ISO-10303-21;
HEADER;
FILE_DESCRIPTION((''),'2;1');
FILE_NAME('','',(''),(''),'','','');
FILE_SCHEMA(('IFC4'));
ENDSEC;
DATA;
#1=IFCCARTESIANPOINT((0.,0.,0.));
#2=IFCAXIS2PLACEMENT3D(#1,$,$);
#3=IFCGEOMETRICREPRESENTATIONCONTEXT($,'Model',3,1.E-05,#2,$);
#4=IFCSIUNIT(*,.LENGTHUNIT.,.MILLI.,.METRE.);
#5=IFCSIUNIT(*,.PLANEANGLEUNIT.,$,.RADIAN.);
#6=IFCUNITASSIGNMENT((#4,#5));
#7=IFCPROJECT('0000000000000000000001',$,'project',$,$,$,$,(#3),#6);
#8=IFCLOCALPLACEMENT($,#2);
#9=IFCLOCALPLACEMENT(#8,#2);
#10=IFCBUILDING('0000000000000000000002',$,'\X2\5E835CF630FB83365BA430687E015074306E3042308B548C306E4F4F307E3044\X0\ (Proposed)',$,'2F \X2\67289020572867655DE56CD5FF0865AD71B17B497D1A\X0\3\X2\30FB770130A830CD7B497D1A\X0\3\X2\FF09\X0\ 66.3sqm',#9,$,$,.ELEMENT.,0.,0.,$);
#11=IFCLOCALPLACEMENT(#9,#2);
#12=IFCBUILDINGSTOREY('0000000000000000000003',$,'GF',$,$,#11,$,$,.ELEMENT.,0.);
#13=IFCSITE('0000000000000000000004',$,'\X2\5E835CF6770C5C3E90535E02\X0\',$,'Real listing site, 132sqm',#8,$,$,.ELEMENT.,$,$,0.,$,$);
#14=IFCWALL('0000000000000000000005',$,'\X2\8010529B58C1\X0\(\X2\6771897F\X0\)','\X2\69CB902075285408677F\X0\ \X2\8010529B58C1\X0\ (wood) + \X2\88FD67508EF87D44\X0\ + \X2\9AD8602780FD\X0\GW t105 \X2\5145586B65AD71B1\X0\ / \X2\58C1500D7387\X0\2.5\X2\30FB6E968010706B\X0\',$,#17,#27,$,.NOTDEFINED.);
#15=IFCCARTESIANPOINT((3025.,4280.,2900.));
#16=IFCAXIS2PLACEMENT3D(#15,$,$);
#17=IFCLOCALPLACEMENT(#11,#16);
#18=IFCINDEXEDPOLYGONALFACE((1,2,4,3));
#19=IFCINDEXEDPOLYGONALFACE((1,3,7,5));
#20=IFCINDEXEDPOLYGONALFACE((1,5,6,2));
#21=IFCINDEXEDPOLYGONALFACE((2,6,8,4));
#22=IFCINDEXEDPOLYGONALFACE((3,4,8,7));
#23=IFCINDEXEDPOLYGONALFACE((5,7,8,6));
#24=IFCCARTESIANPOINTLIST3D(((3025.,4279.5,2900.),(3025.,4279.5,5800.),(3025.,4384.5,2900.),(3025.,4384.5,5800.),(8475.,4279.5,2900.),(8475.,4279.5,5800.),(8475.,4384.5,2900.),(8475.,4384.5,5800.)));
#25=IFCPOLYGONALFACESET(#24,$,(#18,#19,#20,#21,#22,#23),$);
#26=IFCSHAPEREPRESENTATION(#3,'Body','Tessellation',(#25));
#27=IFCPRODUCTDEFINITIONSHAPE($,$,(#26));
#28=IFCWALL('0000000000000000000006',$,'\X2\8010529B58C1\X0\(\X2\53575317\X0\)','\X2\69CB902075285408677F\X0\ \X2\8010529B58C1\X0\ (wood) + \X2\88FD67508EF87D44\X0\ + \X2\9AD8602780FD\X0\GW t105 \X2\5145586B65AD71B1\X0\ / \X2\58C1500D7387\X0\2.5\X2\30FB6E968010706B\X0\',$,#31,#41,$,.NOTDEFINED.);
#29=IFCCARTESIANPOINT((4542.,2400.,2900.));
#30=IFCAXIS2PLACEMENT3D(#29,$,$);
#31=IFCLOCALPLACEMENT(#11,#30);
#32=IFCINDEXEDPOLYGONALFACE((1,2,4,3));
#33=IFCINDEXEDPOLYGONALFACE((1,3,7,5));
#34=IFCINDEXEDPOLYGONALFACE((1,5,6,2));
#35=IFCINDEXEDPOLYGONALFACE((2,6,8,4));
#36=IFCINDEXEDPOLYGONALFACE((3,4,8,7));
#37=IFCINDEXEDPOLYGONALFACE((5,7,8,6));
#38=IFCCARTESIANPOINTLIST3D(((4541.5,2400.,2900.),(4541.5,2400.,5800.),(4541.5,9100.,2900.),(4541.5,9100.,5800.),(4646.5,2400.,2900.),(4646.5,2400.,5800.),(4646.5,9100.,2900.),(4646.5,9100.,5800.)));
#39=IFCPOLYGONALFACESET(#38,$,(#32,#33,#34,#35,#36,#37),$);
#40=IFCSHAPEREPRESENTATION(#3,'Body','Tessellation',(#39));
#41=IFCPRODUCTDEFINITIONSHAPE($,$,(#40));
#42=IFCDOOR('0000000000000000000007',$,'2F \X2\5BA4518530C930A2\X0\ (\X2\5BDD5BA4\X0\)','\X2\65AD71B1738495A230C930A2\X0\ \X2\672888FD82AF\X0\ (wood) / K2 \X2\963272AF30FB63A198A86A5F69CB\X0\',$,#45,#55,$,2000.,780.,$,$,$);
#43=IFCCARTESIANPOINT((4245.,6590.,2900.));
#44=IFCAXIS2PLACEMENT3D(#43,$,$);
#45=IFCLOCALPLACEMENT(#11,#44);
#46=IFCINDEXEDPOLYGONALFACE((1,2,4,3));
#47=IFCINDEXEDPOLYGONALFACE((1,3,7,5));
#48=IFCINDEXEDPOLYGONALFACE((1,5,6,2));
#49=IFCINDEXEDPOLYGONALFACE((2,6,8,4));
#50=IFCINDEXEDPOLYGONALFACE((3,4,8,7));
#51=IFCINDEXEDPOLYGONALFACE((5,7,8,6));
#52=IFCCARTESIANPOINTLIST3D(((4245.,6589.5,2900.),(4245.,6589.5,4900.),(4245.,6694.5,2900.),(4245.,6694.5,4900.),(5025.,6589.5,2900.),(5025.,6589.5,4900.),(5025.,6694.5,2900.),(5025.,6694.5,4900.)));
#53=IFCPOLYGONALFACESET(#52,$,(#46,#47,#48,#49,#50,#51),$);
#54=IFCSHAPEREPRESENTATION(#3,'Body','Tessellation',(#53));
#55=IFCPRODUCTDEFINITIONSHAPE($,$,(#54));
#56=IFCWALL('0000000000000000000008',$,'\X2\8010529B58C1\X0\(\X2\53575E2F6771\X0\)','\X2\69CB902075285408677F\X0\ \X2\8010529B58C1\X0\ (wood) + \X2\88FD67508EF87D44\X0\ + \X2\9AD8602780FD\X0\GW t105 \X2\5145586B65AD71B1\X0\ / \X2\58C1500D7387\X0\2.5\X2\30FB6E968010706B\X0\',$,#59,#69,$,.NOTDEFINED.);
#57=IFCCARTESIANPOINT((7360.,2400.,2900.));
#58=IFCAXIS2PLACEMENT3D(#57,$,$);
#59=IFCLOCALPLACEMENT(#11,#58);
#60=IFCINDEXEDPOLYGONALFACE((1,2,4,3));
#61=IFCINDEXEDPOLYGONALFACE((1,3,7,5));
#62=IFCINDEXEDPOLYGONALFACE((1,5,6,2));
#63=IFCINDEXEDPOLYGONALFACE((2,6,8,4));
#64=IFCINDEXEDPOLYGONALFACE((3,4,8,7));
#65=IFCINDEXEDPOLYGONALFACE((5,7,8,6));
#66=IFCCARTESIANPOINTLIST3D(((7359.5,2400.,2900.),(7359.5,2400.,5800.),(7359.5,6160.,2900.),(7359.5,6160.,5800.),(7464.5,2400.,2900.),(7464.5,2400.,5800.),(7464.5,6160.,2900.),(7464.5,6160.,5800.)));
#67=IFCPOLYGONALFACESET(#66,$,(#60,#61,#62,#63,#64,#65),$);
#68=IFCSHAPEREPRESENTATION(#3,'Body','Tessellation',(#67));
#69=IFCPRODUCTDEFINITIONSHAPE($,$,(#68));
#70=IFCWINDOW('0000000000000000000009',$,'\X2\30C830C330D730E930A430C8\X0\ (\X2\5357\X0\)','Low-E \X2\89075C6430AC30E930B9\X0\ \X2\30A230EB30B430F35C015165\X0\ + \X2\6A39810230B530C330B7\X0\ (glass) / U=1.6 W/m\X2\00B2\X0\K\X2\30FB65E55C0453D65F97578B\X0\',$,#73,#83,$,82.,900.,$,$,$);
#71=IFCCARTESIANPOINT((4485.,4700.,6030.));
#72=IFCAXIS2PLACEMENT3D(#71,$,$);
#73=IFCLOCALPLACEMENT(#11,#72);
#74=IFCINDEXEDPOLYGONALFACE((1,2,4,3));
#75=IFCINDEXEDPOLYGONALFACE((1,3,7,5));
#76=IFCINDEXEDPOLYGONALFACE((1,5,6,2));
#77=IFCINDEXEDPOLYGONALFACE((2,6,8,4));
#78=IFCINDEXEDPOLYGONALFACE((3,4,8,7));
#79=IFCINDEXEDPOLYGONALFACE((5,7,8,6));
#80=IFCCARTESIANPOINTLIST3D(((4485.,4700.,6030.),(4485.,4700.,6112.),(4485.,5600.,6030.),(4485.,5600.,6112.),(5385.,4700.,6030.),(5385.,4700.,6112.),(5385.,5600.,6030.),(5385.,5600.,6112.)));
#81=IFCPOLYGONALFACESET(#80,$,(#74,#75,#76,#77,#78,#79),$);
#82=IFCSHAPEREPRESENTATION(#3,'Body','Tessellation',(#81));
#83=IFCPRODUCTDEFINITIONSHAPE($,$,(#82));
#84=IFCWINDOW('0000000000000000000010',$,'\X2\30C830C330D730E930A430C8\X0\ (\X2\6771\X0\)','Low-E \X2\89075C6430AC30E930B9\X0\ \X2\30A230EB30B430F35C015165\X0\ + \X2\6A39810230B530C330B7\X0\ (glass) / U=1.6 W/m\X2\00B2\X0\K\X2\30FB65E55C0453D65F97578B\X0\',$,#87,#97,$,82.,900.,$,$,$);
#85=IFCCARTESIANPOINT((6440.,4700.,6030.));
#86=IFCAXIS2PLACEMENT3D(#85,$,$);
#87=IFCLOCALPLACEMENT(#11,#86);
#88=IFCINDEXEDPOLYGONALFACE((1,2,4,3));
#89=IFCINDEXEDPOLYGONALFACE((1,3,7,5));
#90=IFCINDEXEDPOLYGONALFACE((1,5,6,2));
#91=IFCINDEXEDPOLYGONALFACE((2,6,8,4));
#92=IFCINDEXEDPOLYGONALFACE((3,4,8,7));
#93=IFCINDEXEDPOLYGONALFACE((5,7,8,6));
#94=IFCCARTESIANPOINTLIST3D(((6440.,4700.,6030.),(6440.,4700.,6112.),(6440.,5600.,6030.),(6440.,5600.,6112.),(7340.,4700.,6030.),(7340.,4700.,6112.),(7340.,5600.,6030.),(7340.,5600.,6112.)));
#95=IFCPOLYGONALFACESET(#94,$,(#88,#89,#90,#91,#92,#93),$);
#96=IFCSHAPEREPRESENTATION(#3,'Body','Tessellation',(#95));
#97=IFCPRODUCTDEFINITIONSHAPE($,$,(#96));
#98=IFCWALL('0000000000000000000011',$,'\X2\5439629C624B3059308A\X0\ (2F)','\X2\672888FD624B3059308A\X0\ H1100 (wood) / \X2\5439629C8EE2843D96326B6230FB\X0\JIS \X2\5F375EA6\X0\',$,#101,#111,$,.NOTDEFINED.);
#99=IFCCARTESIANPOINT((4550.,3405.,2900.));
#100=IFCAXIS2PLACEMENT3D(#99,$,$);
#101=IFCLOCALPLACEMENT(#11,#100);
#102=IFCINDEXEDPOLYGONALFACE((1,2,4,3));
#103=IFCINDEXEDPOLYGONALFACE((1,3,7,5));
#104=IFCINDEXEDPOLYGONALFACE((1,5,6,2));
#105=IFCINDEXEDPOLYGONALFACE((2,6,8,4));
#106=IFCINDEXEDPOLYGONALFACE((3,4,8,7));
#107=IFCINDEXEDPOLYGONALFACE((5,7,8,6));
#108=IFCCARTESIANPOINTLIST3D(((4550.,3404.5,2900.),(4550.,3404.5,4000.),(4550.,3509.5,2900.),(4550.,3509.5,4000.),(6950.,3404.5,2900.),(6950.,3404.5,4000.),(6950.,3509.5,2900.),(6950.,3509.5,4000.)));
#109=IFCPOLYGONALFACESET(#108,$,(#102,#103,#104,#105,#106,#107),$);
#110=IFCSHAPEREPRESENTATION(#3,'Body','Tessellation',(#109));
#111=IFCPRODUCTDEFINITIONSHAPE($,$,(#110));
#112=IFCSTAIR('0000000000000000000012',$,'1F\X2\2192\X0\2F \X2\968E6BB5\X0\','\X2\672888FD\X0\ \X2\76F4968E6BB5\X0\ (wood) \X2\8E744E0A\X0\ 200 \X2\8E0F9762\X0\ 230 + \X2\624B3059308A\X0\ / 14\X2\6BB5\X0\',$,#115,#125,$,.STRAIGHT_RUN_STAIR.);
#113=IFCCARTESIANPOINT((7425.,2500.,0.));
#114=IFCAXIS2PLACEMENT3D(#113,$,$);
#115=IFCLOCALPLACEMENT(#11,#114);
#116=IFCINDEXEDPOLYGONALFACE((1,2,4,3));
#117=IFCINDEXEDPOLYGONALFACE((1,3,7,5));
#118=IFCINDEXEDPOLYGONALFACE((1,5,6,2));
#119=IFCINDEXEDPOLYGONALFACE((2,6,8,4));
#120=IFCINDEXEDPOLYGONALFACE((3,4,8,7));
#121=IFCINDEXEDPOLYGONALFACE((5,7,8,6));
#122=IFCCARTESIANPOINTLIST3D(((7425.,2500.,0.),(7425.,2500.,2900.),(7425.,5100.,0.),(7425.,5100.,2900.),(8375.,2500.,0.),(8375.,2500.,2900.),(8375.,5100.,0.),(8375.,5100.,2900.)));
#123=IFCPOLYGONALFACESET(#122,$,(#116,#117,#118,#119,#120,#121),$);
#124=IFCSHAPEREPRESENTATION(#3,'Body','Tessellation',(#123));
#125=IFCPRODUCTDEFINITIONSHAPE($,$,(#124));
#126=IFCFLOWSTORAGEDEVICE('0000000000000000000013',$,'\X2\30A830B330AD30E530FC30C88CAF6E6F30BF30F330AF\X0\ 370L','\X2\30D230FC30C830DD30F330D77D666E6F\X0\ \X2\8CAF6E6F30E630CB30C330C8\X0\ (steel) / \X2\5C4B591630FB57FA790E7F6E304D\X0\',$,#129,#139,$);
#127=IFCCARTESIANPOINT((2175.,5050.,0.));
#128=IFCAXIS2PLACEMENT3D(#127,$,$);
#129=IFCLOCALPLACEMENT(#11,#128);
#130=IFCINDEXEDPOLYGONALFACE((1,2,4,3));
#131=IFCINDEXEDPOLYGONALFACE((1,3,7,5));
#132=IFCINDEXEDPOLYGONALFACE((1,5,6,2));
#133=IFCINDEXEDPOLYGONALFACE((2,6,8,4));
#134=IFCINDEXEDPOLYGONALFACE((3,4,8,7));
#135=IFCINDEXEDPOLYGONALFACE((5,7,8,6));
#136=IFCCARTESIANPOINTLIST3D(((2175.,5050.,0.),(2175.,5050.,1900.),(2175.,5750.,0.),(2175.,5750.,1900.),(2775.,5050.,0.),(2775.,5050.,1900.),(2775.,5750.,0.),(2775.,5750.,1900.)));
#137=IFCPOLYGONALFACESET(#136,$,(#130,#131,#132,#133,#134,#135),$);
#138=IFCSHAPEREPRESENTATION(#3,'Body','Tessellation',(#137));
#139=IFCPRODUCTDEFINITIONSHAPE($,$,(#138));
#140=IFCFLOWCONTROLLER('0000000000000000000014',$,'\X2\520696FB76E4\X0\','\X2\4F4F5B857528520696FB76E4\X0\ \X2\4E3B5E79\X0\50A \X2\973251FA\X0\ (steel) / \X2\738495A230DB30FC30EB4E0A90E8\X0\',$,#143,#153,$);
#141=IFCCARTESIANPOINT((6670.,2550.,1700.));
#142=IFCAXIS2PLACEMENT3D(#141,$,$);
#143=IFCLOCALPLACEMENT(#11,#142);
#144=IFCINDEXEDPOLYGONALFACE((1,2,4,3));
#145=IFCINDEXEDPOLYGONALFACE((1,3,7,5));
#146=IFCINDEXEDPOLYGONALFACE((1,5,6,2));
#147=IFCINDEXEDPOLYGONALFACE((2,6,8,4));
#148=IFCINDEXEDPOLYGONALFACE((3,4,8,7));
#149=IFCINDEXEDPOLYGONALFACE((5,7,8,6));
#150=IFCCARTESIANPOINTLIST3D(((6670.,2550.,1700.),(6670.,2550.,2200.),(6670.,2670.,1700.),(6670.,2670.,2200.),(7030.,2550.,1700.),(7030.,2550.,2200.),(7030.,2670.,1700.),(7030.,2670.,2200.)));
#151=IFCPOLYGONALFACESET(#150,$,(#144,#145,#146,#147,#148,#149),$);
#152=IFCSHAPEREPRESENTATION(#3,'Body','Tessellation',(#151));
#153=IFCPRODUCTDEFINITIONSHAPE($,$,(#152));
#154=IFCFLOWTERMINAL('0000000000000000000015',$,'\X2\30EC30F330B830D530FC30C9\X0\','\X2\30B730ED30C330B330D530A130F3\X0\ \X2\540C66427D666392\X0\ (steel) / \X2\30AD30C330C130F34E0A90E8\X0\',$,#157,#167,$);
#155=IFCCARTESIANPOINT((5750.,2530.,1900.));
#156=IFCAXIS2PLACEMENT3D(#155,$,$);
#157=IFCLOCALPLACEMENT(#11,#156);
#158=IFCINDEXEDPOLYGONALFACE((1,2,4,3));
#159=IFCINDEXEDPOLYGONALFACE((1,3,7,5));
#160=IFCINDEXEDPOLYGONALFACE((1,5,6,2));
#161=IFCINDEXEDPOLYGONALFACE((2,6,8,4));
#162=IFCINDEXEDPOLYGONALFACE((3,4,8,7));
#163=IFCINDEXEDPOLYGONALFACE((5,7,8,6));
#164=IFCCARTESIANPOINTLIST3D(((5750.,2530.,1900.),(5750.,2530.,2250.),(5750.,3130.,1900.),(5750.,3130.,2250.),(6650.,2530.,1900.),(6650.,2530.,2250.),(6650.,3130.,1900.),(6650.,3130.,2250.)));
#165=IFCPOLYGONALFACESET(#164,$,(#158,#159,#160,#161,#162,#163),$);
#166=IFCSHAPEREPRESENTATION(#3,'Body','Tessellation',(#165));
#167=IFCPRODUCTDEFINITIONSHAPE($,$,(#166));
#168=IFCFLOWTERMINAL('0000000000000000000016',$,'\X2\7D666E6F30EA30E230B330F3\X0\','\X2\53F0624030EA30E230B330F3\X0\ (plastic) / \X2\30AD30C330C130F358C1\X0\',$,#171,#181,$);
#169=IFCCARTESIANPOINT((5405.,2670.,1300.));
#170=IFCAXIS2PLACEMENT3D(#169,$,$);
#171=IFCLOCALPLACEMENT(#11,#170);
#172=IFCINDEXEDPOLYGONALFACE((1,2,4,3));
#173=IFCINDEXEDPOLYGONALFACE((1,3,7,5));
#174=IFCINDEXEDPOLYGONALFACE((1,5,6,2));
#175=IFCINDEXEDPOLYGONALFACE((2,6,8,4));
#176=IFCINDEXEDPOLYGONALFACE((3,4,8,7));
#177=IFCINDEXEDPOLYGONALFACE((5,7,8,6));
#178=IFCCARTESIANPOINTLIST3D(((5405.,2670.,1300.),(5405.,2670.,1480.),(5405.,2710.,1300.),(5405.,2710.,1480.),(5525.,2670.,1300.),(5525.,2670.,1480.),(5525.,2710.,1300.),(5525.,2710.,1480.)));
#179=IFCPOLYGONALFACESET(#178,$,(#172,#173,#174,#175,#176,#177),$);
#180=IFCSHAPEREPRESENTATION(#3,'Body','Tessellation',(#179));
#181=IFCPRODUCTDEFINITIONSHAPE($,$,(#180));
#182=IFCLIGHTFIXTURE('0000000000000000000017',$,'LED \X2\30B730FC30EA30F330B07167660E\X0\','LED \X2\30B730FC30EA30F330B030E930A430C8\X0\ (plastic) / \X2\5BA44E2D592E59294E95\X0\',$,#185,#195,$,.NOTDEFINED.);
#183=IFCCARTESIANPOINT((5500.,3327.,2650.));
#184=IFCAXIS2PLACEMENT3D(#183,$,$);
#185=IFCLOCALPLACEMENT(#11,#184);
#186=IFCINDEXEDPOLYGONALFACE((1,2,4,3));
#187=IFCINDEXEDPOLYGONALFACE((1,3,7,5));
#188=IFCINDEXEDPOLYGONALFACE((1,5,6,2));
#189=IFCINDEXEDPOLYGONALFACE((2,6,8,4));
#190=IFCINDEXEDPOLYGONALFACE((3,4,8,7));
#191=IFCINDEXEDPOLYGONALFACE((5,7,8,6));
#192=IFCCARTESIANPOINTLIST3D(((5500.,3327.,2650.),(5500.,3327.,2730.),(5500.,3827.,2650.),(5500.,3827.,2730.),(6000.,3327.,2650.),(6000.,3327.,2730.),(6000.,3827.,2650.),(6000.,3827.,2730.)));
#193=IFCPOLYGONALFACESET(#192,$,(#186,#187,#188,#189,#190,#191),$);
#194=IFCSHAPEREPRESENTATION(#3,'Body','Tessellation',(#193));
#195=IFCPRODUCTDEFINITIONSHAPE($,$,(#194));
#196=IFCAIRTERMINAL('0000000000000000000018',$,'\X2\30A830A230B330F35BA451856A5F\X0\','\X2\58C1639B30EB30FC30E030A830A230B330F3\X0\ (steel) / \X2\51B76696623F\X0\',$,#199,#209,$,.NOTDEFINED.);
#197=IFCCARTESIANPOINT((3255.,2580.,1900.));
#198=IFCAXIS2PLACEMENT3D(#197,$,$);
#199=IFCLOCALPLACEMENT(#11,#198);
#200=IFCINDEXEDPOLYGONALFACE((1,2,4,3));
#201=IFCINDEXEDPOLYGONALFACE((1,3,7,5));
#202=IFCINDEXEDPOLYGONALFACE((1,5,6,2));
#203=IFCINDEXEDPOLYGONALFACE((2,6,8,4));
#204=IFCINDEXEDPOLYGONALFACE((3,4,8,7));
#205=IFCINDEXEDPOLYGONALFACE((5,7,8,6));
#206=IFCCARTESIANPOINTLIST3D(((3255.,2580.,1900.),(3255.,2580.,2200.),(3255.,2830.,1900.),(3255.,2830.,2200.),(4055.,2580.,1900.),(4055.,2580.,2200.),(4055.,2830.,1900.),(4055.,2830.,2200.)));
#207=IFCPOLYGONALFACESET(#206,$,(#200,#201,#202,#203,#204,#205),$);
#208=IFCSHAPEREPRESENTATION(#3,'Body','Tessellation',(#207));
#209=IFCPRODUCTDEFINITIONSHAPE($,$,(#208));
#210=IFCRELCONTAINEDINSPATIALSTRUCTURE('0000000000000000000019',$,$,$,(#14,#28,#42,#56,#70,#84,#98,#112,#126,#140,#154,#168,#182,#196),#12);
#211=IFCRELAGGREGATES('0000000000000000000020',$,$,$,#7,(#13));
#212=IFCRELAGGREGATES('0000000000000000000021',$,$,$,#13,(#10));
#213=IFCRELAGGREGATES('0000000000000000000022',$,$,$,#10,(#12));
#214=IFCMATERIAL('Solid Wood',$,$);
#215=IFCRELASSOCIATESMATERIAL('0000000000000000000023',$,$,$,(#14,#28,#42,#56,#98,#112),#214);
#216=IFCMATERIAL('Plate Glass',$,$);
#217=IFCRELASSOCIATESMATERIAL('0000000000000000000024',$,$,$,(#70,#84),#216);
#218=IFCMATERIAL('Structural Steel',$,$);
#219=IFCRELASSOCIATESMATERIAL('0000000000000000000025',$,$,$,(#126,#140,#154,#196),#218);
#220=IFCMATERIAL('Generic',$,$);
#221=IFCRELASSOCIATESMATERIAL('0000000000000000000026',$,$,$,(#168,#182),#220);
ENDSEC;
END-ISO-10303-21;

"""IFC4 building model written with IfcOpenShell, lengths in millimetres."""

from ifc_helpers import new_model, si_unit, frame, frame_2d, origin, place, context, project, spatial, rectangle, extrude, material, element, fill, save


model = new_model("IFC4")

# Units and contexts
model_context = context("Model", 3, precision=1e-05, world=origin())
ifc_project = project(units=[si_unit("LENGTHUNIT", "METRE", prefix="MILLI"), si_unit("PLANEANGLEUNIT", "RADIAN")], contexts=[model_context])

# Site, building, storey
site_placement = place(None, origin())
site = spatial("IfcSite", under=ifc_project, at=site_placement, Name="広島県尾道市", ObjectType="Real listing site, 132sqm", CompositionType="ELEMENT", RefElevation=0.0)
building_placement = place(site_placement, origin())
building = spatial("IfcBuilding", under=site, at=building_placement, Name="広島・茶室と縁側のある和の住まい (Proposed)", ObjectType="2F 木造在来工法（断熱等級3・省エネ等級3） 66.3sqm", CompositionType="ELEMENT", ElevationOfRefHeight=0.0, ElevationOfTerrain=0.0)
storey_placement = place(building_placement, origin())
storey = spatial("IfcBuildingStorey", under=building, at=storey_placement, Name="GF", CompositionType="ELEMENT", Elevation=0.0)

# Shared definitions
ifc_material_1 = material(Name="Solid Wood")

# Wall
wall_1_placement = place(storey_placement, frame((3025.0, 4280.0, 2900.0)))
element("IfcWall", 1, at=wall_1_placement, inside=storey, material=ifc_material_1, Name="耐力壁(東西)", Description="構造用合板 耐力壁 (wood) + 製材軸組 + 高性能GW t105 充填断熱 / 壁倍率2.5・準耐火", PredefinedType="NOTDEFINED", context=model_context, shape_type="SweptSolid", body=[
    extrude(rectangle(XDim=5450.0, YDim=105.0, at=frame_2d((2725.0, 52.0))), frame((3025.0, 4280.0, 2900.0)), (0.0, 0.0, 1.0), 2900.0),
])

# Wall, opening, door
wall_2_placement = place(storey_placement, frame((4542.0, 2400.0, 2900.0)))
wall_2 = element("IfcWall", 2, at=wall_2_placement, inside=storey, material=ifc_material_1, Name="耐力壁(南北)", Description="構造用合板 耐力壁 (wood) + 製材軸組 + 高性能GW t105 充填断熱 / 壁倍率2.5・準耐火", PredefinedType="NOTDEFINED", context=model_context, shape_type="SweptSolid", body=[
    extrude(rectangle(XDim=105.0, YDim=6700.0, at=frame_2d((52.0, 3350.0))), frame((4542.0, 2400.0, 2900.0)), (0.0, 0.0, 1.0), 2900.0),
])
opening_placement = place(storey_placement, frame((4245.0, 6590.0, 2900.0)))
opening = element("IfcOpeningElement", 3, at=opening_placement, cuts=wall_2, PredefinedType="NOTDEFINED", context=model_context, shape_type="SweptSolid", body=[
    extrude(rectangle(XDim=780.0, YDim=105.0, at=frame_2d((390.0, 52.0))), frame((4245.0, 6590.0, 2900.0)), (0.0, 0.0, 1.0), 2000.0),
])
door_placement = place(storey_placement, frame((4245.0, 6590.0, 2900.0)))
door = element("IfcDoor", 4, at=door_placement, inside=storey, material=ifc_material_1, Name="2F 室内ドア (寝室)", Description="断熱玄関ドア 木製芯 (wood) / K2 防犯・採風機構", OverallHeight=2000.0, OverallWidth=780.0, context=model_context, shape_type="SweptSolid", body=[
    extrude(rectangle(XDim=780.0, YDim=105.0, at=frame_2d((390.0, 52.0))), frame((4245.0, 6590.0, 2900.0)), (0.0, 0.0, 1.0), 2000.0),
])
fill(opening, door)

# Wall
wall_3_placement = place(storey_placement, frame((7360.0, 2400.0, 2900.0)))
element("IfcWall", 5, at=wall_3_placement, inside=storey, material=ifc_material_1, Name="耐力壁(南帯東)", Description="構造用合板 耐力壁 (wood) + 製材軸組 + 高性能GW t105 充填断熱 / 壁倍率2.5・準耐火", PredefinedType="NOTDEFINED", context=model_context, shape_type="SweptSolid", body=[
    extrude(rectangle(XDim=105.0, YDim=3760.0, at=frame_2d((52.0, 1880.0))), frame((7360.0, 2400.0, 2900.0)), (0.0, 0.0, 1.0), 2900.0),
])

# Windows
ifc_material_2 = material(Name="Plate Glass")
window_1_placement = place(storey_placement, frame((4485.0, 4700.0, 6030.0)))
element("IfcWindow", 6, at=window_1_placement, inside=storey, material=ifc_material_2, Name="トップライト (南)", Description="Low-E 複層ガラス アルゴン封入 + 樹脂サッシ (glass) / U=1.6 W/m²K・日射取得型", OverallHeight=82.0, OverallWidth=900.0, context=model_context, shape_type="SweptSolid", body=[
    extrude(rectangle(XDim=900.0, YDim=900.0, at=frame_2d((450.0, 450.0))), frame((4485.0, 4700.0, 6030.0)), (0.0, 0.0, 1.0), 82.0),
])
window_2_placement = place(storey_placement, frame((6440.0, 4700.0, 6030.0)))
element("IfcWindow", 7, at=window_2_placement, inside=storey, material=ifc_material_2, Name="トップライト (東)", Description="Low-E 複層ガラス アルゴン封入 + 樹脂サッシ (glass) / U=1.6 W/m²K・日射取得型", OverallHeight=82.0, OverallWidth=900.0, context=model_context, shape_type="SweptSolid", body=[
    extrude(rectangle(XDim=900.0, YDim=900.0, at=frame_2d((450.0, 450.0))), frame((6440.0, 4700.0, 6030.0)), (0.0, 0.0, 1.0), 82.0),
])

# Wall
wall_4_placement = place(storey_placement, frame((4550.0, 3405.0, 2900.0)))
element("IfcWall", 8, at=wall_4_placement, inside=storey, material=ifc_material_1, Name="吹抜手すり (2F)", Description="木製手すり H1100 (wood) / 吹抜転落防止・JIS 強度", PredefinedType="NOTDEFINED", context=model_context, shape_type="SweptSolid", body=[
    extrude(rectangle(XDim=2400.0, YDim=105.0, at=frame_2d((1200.0, 52.0))), frame((4550.0, 3405.0, 2900.0)), (0.0, 0.0, 1.0), 1100.0),
])

# Stair
stair_placement = place(storey_placement, frame((7425.0, 2500.0, 0.0)))
element("IfcStair", 9, at=stair_placement, inside=storey, material=ifc_material_1, Name="1F→2F 階段", Description="木製 直階段 (wood) 蹴上 200 踏面 230 + 手すり / 14段", PredefinedType="STRAIGHT_RUN_STAIR", context=model_context, shape_type="SweptSolid", body=[
    extrude(rectangle(XDim=950.0, YDim=2600.0, at=frame_2d((475.0, 1300.0))), frame((7425.0, 2500.0, 0.0)), (0.0, 0.0, 1.0), 2900.0),
])

# Flow storage device
ifc_material_3 = material(Name="Structural Steel")
flow_storage_device_placement = place(storey_placement, frame((2175.0, 5050.0, 0.0)))
element("IfcFlowStorageDevice", 10, at=flow_storage_device_placement, inside=storey, material=ifc_material_3, Name="エコキュート貯湯タンク 370L", Description="ヒートポンプ給湯 貯湯ユニット (steel) / 屋外・基礎置き", context=model_context, shape_type="SweptSolid", body=[
    extrude(rectangle(XDim=600.0, YDim=700.0, at=frame_2d((300.0, 350.0))), frame((2175.0, 5050.0, 0.0)), (0.0, 0.0, 1.0), 1900.0),
])

# Flow controller
flow_controller_placement = place(storey_placement, frame((6670.0, 2550.0, 1700.0)))
element("IfcFlowController", 11, at=flow_controller_placement, inside=storey, material=ifc_material_3, Name="分電盤", Description="住宅用分電盤 主幹50A 露出 (steel) / 玄関ホール上部", context=model_context, shape_type="SweptSolid", body=[
    extrude(rectangle(XDim=360.0, YDim=120.0, at=frame_2d((180.0, 60.0))), frame((6670.0, 2550.0, 1700.0)), (0.0, 0.0, 1.0), 500.0),
])

# Flow terminals
flow_terminal_1_placement = place(storey_placement, frame((5750.0, 2530.0, 1900.0)))
element("IfcFlowTerminal", 12, at=flow_terminal_1_placement, inside=storey, material=ifc_material_3, Name="レンジフード", Description="シロッコファン 同時給排 (steel) / キッチン上部", context=model_context, shape_type="SweptSolid", body=[
    extrude(rectangle(XDim=900.0, YDim=600.0, at=frame_2d((450.0, 300.0))), frame((5750.0, 2530.0, 1900.0)), (0.0, 0.0, 1.0), 350.0),
])
ifc_material_4 = material(Name="Generic")
flow_terminal_2_placement = place(storey_placement, frame((5405.0, 2670.0, 1300.0)))
element("IfcFlowTerminal", 13, at=flow_terminal_2_placement, inside=storey, material=ifc_material_4, Name="給湯リモコン", Description="台所リモコン (plastic) / キッチン壁", context=model_context, shape_type="SweptSolid", body=[
    extrude(rectangle(XDim=120.0, YDim=40.0, at=frame_2d((60.0, 20.0))), frame((5405.0, 2670.0, 1300.0)), (0.0, 0.0, 1.0), 180.0),
])

# Light fixture
light_fixture_1_placement = place(storey_placement, frame((5500.0, 3327.0, 2650.0)))
element("IfcLightFixture", 14, at=light_fixture_1_placement, inside=storey, material=ifc_material_4, Name="LED シーリング照明", Description="LED シーリングライト (plastic) / 室中央天井", PredefinedType="NOTDEFINED", context=model_context, shape_type="SweptSolid", body=[
    extrude(rectangle(XDim=500.0, YDim=500.0, at=frame_2d((250.0, 250.0))), frame((5500.0, 3327.0, 2650.0)), (0.0, 0.0, 1.0), 80.0),
])

# Air terminal
air_terminal_1_placement = place(storey_placement, frame((3255.0, 2580.0, 1900.0)))
element("IfcAirTerminal", 15, at=air_terminal_1_placement, inside=storey, material=ifc_material_3, Name="エアコン室内機", Description="壁掛ルームエアコン (steel) / 冷暖房", PredefinedType="NOTDEFINED", context=model_context, shape_type="SweptSolid", body=[
    extrude(rectangle(XDim=800.0, YDim=250.0, at=frame_2d((400.0, 125.0))), frame((3255.0, 2580.0, 1900.0)), (0.0, 0.0, 1.0), 300.0),
])

save(model, "model.ifc")
